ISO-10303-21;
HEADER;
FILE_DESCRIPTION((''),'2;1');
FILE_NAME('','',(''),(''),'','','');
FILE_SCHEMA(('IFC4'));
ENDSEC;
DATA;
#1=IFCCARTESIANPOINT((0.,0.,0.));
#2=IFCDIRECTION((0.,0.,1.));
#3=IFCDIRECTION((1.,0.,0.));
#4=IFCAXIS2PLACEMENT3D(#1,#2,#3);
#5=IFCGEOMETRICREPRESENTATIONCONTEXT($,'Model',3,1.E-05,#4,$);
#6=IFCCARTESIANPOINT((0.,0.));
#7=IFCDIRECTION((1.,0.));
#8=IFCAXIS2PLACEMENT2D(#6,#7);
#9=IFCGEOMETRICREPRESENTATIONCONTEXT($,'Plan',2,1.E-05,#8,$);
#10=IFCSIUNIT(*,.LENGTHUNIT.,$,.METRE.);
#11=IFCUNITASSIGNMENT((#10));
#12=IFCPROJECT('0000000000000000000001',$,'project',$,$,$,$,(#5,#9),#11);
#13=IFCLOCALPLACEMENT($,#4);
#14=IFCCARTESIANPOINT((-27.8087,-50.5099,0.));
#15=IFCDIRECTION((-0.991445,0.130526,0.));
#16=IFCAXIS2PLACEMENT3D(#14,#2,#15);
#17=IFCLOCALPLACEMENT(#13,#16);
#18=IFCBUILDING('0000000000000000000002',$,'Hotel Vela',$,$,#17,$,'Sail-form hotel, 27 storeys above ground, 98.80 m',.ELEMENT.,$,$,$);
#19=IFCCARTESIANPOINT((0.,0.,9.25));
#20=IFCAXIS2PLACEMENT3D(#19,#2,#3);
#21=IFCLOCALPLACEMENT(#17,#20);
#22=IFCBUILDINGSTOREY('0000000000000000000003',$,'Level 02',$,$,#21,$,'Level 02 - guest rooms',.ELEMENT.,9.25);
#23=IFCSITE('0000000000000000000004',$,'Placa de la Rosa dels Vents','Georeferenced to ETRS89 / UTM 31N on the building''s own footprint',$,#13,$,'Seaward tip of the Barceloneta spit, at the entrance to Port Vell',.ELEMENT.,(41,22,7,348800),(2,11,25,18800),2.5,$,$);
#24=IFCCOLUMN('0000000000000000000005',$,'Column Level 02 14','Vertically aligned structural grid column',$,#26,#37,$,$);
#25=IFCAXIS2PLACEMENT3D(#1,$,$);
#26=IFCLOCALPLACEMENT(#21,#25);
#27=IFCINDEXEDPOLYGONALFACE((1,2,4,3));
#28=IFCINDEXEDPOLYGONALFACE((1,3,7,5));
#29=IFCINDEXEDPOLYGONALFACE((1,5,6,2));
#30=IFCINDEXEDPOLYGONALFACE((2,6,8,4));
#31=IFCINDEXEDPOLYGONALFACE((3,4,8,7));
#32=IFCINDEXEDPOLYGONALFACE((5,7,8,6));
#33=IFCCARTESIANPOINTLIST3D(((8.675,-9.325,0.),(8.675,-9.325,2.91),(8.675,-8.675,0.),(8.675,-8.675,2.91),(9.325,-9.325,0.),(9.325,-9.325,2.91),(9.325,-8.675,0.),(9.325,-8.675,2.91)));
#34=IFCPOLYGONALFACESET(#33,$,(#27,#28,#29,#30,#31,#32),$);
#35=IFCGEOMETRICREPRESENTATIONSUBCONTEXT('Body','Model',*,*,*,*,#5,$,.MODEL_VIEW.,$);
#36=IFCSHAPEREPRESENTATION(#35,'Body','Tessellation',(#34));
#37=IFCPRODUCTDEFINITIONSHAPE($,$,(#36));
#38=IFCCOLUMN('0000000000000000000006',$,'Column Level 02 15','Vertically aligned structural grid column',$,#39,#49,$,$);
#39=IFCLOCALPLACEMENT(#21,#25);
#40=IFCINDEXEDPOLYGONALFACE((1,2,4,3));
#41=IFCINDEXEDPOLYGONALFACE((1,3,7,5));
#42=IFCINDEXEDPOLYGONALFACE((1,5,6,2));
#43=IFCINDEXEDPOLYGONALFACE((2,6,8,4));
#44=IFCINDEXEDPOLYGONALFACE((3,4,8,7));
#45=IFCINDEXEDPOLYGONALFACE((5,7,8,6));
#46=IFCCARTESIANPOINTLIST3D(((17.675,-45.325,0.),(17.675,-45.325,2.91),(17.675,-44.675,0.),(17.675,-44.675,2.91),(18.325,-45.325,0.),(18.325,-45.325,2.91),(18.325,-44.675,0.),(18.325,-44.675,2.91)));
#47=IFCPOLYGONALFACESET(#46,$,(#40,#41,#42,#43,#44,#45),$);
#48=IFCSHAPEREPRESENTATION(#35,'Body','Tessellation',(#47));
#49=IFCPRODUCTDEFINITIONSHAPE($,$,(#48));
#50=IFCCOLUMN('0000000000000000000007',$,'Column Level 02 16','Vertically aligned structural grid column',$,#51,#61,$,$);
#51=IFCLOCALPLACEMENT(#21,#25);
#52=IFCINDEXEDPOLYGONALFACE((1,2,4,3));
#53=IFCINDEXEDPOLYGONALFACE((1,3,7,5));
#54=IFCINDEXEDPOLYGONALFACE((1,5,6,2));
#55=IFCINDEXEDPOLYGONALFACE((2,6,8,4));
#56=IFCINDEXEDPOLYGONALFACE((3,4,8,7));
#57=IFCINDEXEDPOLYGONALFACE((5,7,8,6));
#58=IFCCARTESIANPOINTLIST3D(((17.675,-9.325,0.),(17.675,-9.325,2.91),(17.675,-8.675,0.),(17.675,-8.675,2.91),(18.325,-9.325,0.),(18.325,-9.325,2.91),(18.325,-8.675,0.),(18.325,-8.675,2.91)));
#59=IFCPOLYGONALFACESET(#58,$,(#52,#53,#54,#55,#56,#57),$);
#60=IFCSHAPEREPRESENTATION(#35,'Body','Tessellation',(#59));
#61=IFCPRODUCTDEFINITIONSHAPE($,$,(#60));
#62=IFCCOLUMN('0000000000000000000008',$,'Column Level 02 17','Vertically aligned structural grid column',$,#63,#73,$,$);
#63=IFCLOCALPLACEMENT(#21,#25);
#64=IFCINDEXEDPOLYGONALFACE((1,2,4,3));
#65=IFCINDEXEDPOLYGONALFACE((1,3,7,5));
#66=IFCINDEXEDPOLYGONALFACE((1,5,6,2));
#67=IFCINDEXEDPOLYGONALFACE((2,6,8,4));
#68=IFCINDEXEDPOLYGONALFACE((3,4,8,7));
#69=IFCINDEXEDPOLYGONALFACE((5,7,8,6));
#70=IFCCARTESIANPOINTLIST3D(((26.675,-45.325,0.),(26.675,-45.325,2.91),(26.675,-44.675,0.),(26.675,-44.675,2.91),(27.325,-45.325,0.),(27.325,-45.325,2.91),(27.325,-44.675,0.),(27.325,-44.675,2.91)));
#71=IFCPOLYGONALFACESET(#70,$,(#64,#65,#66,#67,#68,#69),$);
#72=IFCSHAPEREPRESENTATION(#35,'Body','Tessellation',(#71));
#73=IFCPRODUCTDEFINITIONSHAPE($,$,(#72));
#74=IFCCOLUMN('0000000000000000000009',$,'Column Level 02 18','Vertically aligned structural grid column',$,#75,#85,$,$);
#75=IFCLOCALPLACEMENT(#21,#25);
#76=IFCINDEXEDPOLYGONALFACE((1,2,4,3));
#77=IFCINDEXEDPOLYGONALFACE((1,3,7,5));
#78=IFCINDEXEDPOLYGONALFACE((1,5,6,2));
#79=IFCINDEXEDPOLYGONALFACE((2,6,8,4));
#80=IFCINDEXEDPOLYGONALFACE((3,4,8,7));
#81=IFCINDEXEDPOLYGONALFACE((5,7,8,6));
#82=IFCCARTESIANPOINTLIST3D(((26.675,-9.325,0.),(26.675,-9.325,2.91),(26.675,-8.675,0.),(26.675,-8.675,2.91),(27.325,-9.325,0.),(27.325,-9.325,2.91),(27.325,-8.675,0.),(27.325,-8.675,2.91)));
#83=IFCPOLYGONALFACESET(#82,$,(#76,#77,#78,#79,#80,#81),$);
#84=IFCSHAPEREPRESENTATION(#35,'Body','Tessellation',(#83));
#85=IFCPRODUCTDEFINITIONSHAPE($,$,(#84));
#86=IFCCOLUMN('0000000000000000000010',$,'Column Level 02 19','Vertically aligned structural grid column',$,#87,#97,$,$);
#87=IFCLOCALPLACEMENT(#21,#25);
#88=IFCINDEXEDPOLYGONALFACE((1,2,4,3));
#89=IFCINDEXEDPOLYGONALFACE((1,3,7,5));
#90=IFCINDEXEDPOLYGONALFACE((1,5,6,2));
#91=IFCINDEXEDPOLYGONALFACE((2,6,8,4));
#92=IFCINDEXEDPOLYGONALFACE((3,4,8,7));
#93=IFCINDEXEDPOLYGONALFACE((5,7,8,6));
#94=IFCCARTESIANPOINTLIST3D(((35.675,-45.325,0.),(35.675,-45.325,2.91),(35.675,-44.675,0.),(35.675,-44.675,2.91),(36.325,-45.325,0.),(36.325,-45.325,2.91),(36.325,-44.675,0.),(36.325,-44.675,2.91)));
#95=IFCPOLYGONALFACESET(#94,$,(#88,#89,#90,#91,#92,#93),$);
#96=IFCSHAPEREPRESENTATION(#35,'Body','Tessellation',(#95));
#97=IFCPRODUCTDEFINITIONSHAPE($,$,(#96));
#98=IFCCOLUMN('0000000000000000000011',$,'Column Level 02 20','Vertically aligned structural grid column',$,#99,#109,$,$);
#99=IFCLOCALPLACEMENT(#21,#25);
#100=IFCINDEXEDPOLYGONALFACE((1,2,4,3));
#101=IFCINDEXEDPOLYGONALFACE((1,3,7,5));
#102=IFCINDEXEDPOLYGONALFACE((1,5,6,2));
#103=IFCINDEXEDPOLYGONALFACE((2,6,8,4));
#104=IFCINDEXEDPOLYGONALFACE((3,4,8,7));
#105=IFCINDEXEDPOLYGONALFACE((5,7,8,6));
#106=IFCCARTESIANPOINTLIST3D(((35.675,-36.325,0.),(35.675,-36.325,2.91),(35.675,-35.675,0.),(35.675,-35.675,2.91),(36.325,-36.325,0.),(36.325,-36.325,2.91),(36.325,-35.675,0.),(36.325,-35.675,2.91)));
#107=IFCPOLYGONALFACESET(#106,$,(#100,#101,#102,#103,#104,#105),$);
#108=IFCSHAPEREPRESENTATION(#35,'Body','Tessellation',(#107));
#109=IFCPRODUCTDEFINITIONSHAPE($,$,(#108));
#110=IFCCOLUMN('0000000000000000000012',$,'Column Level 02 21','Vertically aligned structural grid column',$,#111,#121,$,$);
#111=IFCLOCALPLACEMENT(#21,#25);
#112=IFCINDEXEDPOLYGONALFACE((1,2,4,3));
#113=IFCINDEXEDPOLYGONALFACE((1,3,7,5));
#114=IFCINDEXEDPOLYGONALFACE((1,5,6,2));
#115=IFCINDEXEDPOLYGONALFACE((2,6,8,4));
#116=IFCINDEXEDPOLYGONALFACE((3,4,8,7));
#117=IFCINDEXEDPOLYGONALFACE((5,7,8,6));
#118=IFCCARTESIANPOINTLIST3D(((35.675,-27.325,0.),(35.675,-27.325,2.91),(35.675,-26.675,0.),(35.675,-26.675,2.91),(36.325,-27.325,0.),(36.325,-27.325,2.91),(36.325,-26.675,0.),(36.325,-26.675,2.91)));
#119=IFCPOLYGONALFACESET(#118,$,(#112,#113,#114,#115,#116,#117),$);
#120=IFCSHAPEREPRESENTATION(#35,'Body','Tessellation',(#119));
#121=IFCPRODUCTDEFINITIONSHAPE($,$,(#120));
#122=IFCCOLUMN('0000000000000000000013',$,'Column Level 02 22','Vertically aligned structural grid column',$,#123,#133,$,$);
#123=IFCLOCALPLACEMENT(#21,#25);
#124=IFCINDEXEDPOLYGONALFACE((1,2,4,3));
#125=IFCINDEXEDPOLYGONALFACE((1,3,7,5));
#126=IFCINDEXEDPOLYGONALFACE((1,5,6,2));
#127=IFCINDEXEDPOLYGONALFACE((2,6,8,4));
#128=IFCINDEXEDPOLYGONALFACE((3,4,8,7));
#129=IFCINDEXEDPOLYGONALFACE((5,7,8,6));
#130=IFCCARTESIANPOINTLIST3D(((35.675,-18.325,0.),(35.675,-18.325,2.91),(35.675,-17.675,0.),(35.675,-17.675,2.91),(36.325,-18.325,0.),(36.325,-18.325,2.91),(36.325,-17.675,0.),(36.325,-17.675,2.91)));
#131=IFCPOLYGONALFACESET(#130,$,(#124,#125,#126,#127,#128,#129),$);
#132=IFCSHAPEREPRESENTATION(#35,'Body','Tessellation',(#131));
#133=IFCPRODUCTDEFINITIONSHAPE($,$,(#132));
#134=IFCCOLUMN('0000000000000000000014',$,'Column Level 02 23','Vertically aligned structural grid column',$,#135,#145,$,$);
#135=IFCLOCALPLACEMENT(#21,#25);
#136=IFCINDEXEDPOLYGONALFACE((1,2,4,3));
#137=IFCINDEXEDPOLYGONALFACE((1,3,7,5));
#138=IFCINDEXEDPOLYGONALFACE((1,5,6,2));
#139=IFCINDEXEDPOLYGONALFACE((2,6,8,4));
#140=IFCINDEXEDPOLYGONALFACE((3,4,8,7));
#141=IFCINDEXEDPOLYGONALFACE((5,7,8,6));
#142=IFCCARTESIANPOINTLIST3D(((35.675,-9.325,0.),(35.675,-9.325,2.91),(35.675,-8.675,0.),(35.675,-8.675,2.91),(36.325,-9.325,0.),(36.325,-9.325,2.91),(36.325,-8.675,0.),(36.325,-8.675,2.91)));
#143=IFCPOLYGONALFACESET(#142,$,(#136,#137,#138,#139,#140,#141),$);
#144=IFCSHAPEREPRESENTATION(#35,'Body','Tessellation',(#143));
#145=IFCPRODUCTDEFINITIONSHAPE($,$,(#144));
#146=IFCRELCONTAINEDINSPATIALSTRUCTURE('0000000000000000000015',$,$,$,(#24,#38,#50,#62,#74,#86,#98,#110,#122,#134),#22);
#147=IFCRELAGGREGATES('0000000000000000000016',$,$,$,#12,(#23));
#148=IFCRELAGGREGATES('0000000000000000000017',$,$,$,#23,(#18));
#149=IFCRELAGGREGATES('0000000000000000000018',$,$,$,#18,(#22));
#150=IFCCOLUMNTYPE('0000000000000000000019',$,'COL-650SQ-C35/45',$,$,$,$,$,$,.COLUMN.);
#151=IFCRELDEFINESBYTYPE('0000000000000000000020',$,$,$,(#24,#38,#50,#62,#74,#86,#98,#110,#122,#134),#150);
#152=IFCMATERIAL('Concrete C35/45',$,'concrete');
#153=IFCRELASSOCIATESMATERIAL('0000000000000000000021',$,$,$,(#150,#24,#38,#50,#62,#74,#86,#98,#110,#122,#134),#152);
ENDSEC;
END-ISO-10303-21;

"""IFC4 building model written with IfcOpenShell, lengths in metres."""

from ifc_helpers import new_model, si_unit, frame, origin_with_axes, origin_2d_with_axis, place, context, subcontext, project, spatial, line, indexed_curve, rectangle, outline, extrude, material, material_profile, profile_set, profile_usage, type_object, element, save


model = new_model("IFC4")

# Units and contexts
model_context = context("Model", 3, precision=1e-05, world=origin_with_axes())
plan_context = context("Plan", 2, precision=1e-05, world=origin_2d_with_axis())
body_context = subcontext(model_context, "Body", "Model", "MODEL_VIEW")
ifc_project = project(units=[si_unit("LENGTHUNIT", "METRE")], contexts=[model_context, plan_context])

# Site, building, storey
site_placement = place(None, origin_with_axes())
site = spatial("IfcSite", under=ifc_project, at=site_placement, Name="Placa de la Rosa dels Vents", Description="Georeferenced to ETRS89 / UTM 31N on the building's own footprint", LongName="Seaward tip of the Barceloneta spit, at the entrance to Port Vell", CompositionType="ELEMENT", RefLatitude=(41, 22, 7, 348800), RefLongitude=(2, 11, 25, 18800), RefElevation=2.5)
building_placement = place(site_placement, frame((-27.8087, -50.5099, 0.0), z_axis=(0.0, 0.0, 1.0), x_axis=(-0.991445, 0.130526, 0.0)))
building = spatial("IfcBuilding", under=site, at=building_placement, Name="Hotel Vela", LongName="Sail-form hotel, 27 storeys above ground, 98.80 m", CompositionType="ELEMENT")
storey_placement = place(building_placement, frame((0.0, 0.0, 9.25), z_axis=(0.0, 0.0, 1.0), x_axis=(1.0, 0.0, 0.0)))
storey = spatial("IfcBuildingStorey", under=building, at=storey_placement, Name="Level 02", LongName="Level 02 - guest rooms", CompositionType="ELEMENT", Elevation=9.25)

# Columns
ifc_material = material(Name="Concrete C35/45", Category="concrete")
ifc_material_profile = material_profile(ifc_material, rectangle(XDim=0.65, YDim=0.65))
ifc_profile_set = profile_set([ifc_material_profile], Name="COL-650SQ-C35/45")
column_type = type_object("IfcColumnType", Name="COL-650SQ-C35/45", PredefinedType="COLUMN", material=ifc_profile_set)
ifc_profile_usage_1 = profile_usage(ifc_profile_set)
column_1_placement = place(storey_placement, frame((8.675, -9.325, 0.0), z_axis=(0.0, 0.0, 1.0), x_axis=(1.0, 0.0, 0.0)))
element("IfcColumn", 1, at=column_1_placement, inside=storey, type_object=column_type, material=ifc_profile_usage_1, Name="Column Level 02 14", Description="Vertically aligned structural grid column", context=body_context, shape_type="SweptSolid", body=[
    extrude(outline(indexed_curve([(0.0, 0.0), (0.65, 0.0), (0.65, 0.65), (0.0, 0.65)], segments=[line(1, 2, 3, 4, 1)])), origin_with_axes(), (0.0, 0.0, 1.0), 2.91),
])
ifc_profile_usage_2 = profile_usage(ifc_profile_set)
column_2_placement = place(storey_placement, frame((17.675, -45.325, 0.0), z_axis=(0.0, 0.0, 1.0), x_axis=(1.0, 0.0, 0.0)))
element("IfcColumn", 2, at=column_2_placement, inside=storey, type_object=column_type, material=ifc_profile_usage_2, Name="Column Level 02 15", Description="Vertically aligned structural grid column", context=body_context, shape_type="SweptSolid", body=[
    extrude(outline(indexed_curve([(0.0, 0.0), (0.65, 0.0), (0.65, 0.65), (0.0, 0.65)], segments=[line(1, 2, 3, 4, 1)])), origin_with_axes(), (0.0, 0.0, 1.0), 2.91),
])
ifc_profile_usage_3 = profile_usage(ifc_profile_set)
column_3_placement = place(storey_placement, frame((17.675, -9.325, 0.0), z_axis=(0.0, 0.0, 1.0), x_axis=(1.0, 0.0, 0.0)))
element("IfcColumn", 3, at=column_3_placement, inside=storey, type_object=column_type, material=ifc_profile_usage_3, Name="Column Level 02 16", Description="Vertically aligned structural grid column", context=body_context, shape_type="SweptSolid", body=[
    extrude(outline(indexed_curve([(0.0, 0.0), (0.65, 0.0), (0.65, 0.65), (0.0, 0.65)], segments=[line(1, 2, 3, 4, 1)])), origin_with_axes(), (0.0, 0.0, 1.0), 2.91),
])
ifc_profile_usage_4 = profile_usage(ifc_profile_set)
column_4_placement = place(storey_placement, frame((26.675, -45.325, 0.0), z_axis=(0.0, 0.0, 1.0), x_axis=(1.0, 0.0, 0.0)))
element("IfcColumn", 4, at=column_4_placement, inside=storey, type_object=column_type, material=ifc_profile_usage_4, Name="Column Level 02 17", Description="Vertically aligned structural grid column", context=body_context, shape_type="SweptSolid", body=[
    extrude(outline(indexed_curve([(0.0, 0.0), (0.65, 0.0), (0.65, 0.65), (0.0, 0.65)], segments=[line(1, 2, 3, 4, 1)])), origin_with_axes(), (0.0, 0.0, 1.0), 2.91),
])
ifc_profile_usage_5 = profile_usage(ifc_profile_set)
column_5_placement = place(storey_placement, frame((26.675, -9.325, 0.0), z_axis=(0.0, 0.0, 1.0), x_axis=(1.0, 0.0, 0.0)))
element("IfcColumn", 5, at=column_5_placement, inside=storey, type_object=column_type, material=ifc_profile_usage_5, Name="Column Level 02 18", Description="Vertically aligned structural grid column", context=body_context, shape_type="SweptSolid", body=[
    extrude(outline(indexed_curve([(0.0, 0.0), (0.65, 0.0), (0.65, 0.65), (0.0, 0.65)], segments=[line(1, 2, 3, 4, 1)])), origin_with_axes(), (0.0, 0.0, 1.0), 2.91),
])
ifc_profile_usage_6 = profile_usage(ifc_profile_set)
column_6_placement = place(storey_placement, frame((35.675, -45.325, 0.0), z_axis=(0.0, 0.0, 1.0), x_axis=(1.0, 0.0, 0.0)))
element("IfcColumn", 6, at=column_6_placement, inside=storey, type_object=column_type, material=ifc_profile_usage_6, Name="Column Level 02 19", Description="Vertically aligned structural grid column", context=body_context, shape_type="SweptSolid", body=[
    extrude(outline(indexed_curve([(0.0, 0.0), (0.65, 0.0), (0.65, 0.65), (0.0, 0.65)], segments=[line(1, 2, 3, 4, 1)])), origin_with_axes(), (0.0, 0.0, 1.0), 2.91),
])
ifc_profile_usage_7 = profile_usage(ifc_profile_set)
column_7_placement = place(storey_placement, frame((35.675, -36.325, 0.0), z_axis=(0.0, 0.0, 1.0), x_axis=(1.0, 0.0, 0.0)))
element("IfcColumn", 7, at=column_7_placement, inside=storey, type_object=column_type, material=ifc_profile_usage_7, Name="Column Level 02 20", Description="Vertically aligned structural grid column", context=body_context, shape_type="SweptSolid", body=[
    extrude(outline(indexed_curve([(0.0, 0.0), (0.65, 0.0), (0.65, 0.65), (0.0, 0.65)], segments=[line(1, 2, 3, 4, 1)])), origin_with_axes(), (0.0, 0.0, 1.0), 2.91),
])
ifc_profile_usage_8 = profile_usage(ifc_profile_set)
column_8_placement = place(storey_placement, frame((35.675, -27.325, 0.0), z_axis=(0.0, 0.0, 1.0), x_axis=(1.0, 0.0, 0.0)))
element("IfcColumn", 8, at=column_8_placement, inside=storey, type_object=column_type, material=ifc_profile_usage_8, Name="Column Level 02 21", Description="Vertically aligned structural grid column", context=body_context, shape_type="SweptSolid", body=[
    extrude(outline(indexed_curve([(0.0, 0.0), (0.65, 0.0), (0.65, 0.65), (0.0, 0.65)], segments=[line(1, 2, 3, 4, 1)])), origin_with_axes(), (0.0, 0.0, 1.0), 2.91),
])
ifc_profile_usage_9 = profile_usage(ifc_profile_set)
column_9_placement = place(storey_placement, frame((35.675, -18.325, 0.0), z_axis=(0.0, 0.0, 1.0), x_axis=(1.0, 0.0, 0.0)))
element("IfcColumn", 9, at=column_9_placement, inside=storey, type_object=column_type, material=ifc_profile_usage_9, Name="Column Level 02 22", Description="Vertically aligned structural grid column", context=body_context, shape_type="SweptSolid", body=[
    extrude(outline(indexed_curve([(0.0, 0.0), (0.65, 0.0), (0.65, 0.65), (0.0, 0.65)], segments=[line(1, 2, 3, 4, 1)])), origin_with_axes(), (0.0, 0.0, 1.0), 2.91),
])
ifc_profile_usage_10 = profile_usage(ifc_profile_set)
column_10_placement = place(storey_placement, frame((35.675, -9.325, 0.0), z_axis=(0.0, 0.0, 1.0), x_axis=(1.0, 0.0, 0.0)))
element("IfcColumn", 10, at=column_10_placement, inside=storey, type_object=column_type, material=ifc_profile_usage_10, Name="Column Level 02 23", Description="Vertically aligned structural grid column", context=body_context, shape_type="SweptSolid", body=[
    extrude(outline(indexed_curve([(0.0, 0.0), (0.65, 0.0), (0.65, 0.65), (0.0, 0.65)], segments=[line(1, 2, 3, 4, 1)])), origin_with_axes(), (0.0, 0.0, 1.0), 2.91),
])

save(model, "model.ifc")
